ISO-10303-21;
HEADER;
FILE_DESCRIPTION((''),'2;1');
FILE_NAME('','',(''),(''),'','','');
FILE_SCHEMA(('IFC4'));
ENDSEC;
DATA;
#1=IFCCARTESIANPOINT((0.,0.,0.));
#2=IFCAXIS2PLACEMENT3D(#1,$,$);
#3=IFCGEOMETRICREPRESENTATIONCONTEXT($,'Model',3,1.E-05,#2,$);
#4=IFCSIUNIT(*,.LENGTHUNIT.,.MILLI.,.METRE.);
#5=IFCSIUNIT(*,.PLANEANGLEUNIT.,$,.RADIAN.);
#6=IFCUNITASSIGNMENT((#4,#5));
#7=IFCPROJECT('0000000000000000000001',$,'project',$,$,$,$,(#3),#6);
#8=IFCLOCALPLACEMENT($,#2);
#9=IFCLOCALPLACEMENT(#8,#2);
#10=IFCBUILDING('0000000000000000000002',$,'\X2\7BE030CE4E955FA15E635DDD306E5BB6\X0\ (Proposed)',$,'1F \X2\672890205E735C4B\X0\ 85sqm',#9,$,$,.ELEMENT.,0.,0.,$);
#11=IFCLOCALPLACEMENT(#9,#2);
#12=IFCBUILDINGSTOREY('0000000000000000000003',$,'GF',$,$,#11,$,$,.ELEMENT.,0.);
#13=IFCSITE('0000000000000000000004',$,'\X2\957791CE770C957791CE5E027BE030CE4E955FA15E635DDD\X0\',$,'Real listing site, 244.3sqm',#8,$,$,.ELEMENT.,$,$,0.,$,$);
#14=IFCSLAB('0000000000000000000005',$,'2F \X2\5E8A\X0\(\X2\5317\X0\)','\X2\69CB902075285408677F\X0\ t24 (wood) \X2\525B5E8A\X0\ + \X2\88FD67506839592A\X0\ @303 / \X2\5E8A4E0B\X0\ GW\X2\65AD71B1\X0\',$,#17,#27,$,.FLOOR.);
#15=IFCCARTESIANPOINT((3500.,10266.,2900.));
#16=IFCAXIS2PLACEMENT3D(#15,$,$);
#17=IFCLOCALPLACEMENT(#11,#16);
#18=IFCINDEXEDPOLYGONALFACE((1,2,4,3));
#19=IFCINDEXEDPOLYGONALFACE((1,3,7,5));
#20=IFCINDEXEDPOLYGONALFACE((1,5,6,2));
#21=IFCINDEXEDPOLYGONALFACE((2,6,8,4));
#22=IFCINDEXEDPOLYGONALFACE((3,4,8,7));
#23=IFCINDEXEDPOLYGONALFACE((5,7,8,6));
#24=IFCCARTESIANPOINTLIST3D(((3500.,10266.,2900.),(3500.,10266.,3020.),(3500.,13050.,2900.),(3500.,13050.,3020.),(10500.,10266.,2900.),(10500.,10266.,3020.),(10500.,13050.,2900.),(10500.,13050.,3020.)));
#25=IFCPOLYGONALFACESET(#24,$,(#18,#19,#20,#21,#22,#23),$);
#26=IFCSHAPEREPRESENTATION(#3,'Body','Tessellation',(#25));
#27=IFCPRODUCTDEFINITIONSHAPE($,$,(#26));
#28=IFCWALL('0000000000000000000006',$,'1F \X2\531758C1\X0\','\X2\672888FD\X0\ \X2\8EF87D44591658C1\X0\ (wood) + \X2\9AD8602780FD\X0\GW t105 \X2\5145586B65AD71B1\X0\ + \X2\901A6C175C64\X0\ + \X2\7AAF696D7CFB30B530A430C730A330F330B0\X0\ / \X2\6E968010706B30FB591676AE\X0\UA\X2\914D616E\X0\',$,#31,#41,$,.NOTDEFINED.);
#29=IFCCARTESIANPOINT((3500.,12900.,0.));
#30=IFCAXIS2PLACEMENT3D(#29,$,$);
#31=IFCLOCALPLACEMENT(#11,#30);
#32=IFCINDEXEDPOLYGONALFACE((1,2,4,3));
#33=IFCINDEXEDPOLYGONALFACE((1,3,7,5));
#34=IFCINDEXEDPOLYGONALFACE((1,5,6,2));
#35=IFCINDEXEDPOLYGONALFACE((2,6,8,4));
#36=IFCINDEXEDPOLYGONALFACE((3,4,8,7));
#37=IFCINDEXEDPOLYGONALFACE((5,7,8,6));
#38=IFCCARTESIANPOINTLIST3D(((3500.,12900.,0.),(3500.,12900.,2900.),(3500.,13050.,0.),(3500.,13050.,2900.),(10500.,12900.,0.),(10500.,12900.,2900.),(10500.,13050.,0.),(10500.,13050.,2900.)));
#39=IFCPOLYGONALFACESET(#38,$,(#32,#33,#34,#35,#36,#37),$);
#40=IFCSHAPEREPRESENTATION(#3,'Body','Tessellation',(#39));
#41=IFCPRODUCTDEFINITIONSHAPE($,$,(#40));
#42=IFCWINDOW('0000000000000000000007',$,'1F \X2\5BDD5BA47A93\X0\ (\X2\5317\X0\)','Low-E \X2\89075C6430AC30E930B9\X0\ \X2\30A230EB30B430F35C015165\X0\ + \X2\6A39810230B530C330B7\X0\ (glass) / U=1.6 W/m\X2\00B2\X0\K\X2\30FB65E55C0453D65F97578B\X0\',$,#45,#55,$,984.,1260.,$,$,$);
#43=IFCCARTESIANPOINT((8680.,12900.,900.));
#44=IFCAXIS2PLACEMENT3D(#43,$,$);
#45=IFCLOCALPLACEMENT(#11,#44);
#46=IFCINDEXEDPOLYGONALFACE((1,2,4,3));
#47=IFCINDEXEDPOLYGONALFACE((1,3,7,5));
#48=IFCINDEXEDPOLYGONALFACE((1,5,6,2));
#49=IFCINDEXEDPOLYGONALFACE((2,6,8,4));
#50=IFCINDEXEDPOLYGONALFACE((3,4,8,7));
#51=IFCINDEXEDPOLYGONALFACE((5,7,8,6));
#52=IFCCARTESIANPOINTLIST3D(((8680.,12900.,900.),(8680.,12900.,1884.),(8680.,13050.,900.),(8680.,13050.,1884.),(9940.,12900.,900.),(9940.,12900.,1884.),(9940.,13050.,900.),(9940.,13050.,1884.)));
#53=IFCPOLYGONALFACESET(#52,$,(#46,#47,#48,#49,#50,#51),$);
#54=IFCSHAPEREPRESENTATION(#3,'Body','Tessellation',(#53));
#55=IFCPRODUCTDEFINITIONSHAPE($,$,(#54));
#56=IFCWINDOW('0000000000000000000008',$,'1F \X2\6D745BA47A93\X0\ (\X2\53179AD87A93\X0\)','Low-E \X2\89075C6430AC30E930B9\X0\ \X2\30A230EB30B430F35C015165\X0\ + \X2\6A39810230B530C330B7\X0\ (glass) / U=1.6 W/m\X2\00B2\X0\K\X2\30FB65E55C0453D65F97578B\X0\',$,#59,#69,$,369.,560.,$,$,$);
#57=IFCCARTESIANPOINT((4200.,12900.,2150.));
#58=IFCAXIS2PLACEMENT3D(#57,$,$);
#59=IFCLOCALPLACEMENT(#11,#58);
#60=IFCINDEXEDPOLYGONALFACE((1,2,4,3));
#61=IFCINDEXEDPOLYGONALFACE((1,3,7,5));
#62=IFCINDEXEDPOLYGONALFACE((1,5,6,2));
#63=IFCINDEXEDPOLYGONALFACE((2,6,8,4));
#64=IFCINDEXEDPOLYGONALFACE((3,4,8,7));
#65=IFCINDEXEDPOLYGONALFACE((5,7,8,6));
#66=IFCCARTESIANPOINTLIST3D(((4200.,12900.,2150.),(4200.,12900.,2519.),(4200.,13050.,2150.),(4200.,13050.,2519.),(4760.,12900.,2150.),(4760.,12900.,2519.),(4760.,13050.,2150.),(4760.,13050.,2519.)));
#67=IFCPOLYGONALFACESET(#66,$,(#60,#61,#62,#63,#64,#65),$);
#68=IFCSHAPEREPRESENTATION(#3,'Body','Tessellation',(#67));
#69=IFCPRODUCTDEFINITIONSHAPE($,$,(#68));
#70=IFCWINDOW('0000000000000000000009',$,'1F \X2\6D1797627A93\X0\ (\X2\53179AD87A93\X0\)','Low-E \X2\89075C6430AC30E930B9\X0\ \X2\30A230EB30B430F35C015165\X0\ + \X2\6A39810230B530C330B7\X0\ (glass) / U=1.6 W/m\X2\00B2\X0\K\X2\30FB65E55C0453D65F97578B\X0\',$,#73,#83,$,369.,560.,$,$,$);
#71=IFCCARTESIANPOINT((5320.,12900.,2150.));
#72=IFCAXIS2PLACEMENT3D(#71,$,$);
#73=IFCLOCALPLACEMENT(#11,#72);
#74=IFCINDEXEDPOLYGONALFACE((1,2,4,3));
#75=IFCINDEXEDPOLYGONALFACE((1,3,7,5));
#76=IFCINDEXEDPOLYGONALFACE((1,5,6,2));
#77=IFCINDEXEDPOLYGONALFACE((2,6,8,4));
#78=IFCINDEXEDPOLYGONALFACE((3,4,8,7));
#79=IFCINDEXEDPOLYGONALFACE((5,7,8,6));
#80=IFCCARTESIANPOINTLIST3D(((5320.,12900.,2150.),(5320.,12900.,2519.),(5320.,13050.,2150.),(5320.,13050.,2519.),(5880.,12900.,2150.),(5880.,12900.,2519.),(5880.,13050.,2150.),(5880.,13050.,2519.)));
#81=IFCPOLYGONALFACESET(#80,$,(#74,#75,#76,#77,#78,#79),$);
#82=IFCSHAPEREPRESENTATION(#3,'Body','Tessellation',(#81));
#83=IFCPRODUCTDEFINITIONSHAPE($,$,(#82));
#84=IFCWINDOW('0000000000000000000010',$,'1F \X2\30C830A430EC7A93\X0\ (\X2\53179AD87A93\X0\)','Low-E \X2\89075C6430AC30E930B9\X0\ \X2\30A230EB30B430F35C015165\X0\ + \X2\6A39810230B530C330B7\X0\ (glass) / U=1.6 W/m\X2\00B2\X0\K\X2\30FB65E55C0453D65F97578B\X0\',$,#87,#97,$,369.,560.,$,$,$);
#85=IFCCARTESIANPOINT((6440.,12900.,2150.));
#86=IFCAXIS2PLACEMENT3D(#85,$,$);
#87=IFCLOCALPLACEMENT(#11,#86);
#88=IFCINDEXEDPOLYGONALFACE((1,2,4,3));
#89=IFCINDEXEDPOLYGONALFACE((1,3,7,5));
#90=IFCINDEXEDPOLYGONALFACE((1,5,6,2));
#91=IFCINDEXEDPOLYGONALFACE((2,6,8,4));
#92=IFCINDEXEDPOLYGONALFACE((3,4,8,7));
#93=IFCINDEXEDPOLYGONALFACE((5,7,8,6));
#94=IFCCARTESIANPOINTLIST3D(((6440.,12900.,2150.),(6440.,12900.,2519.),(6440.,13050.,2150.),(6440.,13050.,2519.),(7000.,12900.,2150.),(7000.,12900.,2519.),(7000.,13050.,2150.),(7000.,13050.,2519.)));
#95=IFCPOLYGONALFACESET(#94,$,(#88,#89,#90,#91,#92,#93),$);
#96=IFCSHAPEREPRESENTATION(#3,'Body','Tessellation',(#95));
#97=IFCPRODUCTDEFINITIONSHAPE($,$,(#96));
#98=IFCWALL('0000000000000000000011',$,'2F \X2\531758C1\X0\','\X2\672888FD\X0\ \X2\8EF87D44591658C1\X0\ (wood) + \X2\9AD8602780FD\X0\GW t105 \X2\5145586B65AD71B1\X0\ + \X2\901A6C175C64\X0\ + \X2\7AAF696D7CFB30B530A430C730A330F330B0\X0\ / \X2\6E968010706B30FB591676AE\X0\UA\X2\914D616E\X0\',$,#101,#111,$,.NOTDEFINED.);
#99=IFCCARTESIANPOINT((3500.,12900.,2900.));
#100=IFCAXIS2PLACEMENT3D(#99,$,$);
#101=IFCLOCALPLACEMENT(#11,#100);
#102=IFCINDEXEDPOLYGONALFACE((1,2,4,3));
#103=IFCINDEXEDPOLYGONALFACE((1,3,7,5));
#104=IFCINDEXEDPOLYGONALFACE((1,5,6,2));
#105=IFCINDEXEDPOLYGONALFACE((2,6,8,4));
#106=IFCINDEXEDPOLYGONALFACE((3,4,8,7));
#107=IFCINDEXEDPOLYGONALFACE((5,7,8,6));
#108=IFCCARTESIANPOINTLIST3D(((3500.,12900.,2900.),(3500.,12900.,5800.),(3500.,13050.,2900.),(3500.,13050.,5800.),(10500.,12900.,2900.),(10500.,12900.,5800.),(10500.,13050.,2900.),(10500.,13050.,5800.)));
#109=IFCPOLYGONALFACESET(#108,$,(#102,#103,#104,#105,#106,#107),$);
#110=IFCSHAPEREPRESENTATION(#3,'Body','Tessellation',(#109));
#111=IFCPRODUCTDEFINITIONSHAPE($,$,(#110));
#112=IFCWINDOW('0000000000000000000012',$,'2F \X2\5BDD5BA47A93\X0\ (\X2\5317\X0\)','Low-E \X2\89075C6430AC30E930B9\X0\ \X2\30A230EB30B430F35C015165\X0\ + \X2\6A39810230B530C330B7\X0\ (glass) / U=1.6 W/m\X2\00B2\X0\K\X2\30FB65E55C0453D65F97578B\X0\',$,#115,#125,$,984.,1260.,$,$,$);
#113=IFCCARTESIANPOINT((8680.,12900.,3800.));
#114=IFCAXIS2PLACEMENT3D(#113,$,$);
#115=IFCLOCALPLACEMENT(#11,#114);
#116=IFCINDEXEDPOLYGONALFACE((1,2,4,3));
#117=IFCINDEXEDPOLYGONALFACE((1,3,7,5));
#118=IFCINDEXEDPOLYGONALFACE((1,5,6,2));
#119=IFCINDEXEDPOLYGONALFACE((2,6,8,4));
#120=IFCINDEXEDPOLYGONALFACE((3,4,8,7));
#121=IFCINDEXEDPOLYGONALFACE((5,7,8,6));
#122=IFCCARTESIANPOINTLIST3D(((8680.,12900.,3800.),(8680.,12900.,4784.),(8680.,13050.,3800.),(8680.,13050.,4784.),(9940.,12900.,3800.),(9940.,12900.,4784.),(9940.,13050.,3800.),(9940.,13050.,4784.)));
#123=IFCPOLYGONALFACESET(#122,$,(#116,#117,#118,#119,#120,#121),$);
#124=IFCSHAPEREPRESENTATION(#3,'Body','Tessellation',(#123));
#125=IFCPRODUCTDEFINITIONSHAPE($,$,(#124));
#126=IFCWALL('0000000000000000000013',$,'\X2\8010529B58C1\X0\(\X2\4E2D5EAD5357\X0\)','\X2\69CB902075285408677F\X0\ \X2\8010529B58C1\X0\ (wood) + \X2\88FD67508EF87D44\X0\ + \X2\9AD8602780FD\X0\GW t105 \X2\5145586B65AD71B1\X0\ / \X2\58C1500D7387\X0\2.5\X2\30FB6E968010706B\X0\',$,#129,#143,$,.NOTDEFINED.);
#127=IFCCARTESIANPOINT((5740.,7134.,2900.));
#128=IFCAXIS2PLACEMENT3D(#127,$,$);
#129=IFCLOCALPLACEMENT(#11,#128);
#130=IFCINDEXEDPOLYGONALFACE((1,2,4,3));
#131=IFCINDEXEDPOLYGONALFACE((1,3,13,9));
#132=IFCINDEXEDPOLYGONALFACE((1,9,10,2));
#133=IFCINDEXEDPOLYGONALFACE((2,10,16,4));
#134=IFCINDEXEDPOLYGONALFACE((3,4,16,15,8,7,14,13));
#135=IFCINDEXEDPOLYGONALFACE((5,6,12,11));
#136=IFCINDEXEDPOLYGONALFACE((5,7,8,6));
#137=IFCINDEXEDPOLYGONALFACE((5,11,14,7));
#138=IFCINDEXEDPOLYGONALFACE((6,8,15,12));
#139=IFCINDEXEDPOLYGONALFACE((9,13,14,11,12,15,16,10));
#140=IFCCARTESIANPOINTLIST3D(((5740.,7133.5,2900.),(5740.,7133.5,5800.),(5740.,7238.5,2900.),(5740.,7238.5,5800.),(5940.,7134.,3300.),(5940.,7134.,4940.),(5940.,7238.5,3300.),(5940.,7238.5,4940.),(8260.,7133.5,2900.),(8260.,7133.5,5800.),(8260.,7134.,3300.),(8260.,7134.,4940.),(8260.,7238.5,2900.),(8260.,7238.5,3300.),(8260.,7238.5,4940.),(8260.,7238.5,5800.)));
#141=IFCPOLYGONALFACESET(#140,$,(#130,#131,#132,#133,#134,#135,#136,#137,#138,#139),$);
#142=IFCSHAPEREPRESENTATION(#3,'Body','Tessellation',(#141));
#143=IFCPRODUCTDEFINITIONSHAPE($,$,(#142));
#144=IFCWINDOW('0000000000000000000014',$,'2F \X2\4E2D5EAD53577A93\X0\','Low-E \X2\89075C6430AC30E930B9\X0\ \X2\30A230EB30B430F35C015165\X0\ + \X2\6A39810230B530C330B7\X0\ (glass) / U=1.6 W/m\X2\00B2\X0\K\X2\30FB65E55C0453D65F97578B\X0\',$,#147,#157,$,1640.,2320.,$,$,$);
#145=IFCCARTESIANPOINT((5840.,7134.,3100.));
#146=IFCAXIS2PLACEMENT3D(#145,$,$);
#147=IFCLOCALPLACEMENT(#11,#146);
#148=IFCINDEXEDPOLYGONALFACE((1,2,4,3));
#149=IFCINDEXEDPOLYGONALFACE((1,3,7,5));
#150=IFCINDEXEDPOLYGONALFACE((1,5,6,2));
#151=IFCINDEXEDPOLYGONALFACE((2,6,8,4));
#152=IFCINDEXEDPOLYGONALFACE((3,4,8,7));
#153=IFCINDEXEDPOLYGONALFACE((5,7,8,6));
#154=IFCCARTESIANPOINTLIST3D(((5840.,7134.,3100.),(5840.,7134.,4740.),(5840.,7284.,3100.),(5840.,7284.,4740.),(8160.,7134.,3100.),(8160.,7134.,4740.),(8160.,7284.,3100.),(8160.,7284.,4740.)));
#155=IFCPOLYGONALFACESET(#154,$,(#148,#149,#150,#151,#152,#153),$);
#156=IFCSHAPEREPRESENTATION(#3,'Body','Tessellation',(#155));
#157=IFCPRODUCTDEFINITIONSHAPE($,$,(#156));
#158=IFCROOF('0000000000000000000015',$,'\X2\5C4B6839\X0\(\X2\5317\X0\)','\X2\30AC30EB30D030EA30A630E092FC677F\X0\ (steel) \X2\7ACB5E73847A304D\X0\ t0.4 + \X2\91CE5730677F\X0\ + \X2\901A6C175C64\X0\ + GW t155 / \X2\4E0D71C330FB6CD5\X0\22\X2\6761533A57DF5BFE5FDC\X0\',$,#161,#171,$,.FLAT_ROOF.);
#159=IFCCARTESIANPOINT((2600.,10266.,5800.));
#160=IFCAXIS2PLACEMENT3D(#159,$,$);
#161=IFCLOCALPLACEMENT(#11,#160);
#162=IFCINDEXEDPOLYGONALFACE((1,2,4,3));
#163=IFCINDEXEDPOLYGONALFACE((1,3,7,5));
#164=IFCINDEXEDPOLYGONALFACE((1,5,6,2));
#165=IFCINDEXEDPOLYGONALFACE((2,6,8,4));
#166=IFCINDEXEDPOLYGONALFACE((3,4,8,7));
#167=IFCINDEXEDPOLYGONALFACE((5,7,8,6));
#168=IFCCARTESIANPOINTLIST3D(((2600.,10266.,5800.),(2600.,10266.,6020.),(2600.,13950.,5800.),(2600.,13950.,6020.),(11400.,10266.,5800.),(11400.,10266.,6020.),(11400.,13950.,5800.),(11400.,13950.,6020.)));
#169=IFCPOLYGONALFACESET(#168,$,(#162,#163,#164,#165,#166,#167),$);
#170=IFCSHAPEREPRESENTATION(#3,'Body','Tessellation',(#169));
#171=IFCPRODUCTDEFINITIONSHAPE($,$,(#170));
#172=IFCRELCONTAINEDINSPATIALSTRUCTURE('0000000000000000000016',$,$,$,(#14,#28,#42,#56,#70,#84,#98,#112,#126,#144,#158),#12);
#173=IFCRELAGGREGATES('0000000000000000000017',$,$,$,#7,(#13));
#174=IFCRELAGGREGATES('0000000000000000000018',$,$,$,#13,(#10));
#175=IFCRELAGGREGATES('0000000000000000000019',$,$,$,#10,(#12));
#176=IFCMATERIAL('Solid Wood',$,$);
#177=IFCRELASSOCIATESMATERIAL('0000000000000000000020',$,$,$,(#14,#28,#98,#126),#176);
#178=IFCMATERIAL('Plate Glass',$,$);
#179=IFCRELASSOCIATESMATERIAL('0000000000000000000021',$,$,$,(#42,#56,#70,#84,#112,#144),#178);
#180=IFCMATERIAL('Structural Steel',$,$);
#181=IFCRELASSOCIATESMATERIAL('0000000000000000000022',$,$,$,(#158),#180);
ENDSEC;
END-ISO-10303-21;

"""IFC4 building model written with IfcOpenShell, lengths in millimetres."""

from ifc_helpers import new_model, si_unit, frame, frame_2d, origin, place, context, project, spatial, rectangle, extrude, material, element, fill, save


model = new_model("IFC4")

# Units and contexts
model_context = context("Model", 3, precision=1e-05, world=origin())
ifc_project = project(units=[si_unit("LENGTHUNIT", "METRE", prefix="MILLI"), si_unit("PLANEANGLEUNIT", "RADIAN")], contexts=[model_context])

# Site, building, storey
site_placement = place(None, origin())
site = spatial("IfcSite", under=ifc_project, at=site_placement, Name="長野県長野市篠ノ井御幣川", ObjectType="Real listing site, 244.3sqm", CompositionType="ELEMENT", RefElevation=0.0)
building_placement = place(site_placement, origin())
building = spatial("IfcBuilding", under=site, at=building_placement, Name="篠ノ井御幣川の家 (Proposed)", ObjectType="1F 木造平屋 85sqm", CompositionType="ELEMENT", ElevationOfRefHeight=0.0, ElevationOfTerrain=0.0)
storey_placement = place(building_placement, origin())
storey = spatial("IfcBuildingStorey", under=building, at=storey_placement, Name="GF", CompositionType="ELEMENT", Elevation=0.0)

# Slab
ifc_material_1 = material(Name="Solid Wood")
slab_1_placement = place(storey_placement, frame((3500.0, 10266.0, 2900.0)))
element("IfcSlab", 1, at=slab_1_placement, inside=storey, material=ifc_material_1, Name="2F 床(北)", Description="構造用合板 t24 (wood) 剛床 + 製材根太 @303 / 床下 GW断熱", PredefinedType="FLOOR", context=model_context, shape_type="SweptSolid", body=[
    extrude(rectangle(XDim=7000.0, YDim=2784.0, at=frame_2d((3500.0, 1392.0))), frame((3500.0, 10266.0, 2900.0)), (0.0, 0.0, 1.0), 120.0),
])

# Wall, openings, windows
wall_1_placement = place(storey_placement, frame((3500.0, 12900.0, 0.0)))
wall_1 = element("IfcWall", 2, at=wall_1_placement, inside=storey, material=ifc_material_1, Name="1F 北壁", Description="木製 軸組外壁 (wood) + 高性能GW t105 充填断熱 + 通気層 + 窯業系サイディング / 準耐火・外皮UA配慮", PredefinedType="NOTDEFINED", context=model_context, shape_type="SweptSolid", body=[
    extrude(rectangle(XDim=7000.0, YDim=150.0, at=frame_2d((3500.0, 75.0))), frame((3500.0, 12900.0, 0.0)), (0.0, 0.0, 1.0), 2900.0),
])
opening_1_placement = place(storey_placement, frame((8680.0, 12900.0, 900.0)))
opening_1 = element("IfcOpeningElement", 3, at=opening_1_placement, cuts=wall_1, PredefinedType="NOTDEFINED", context=model_context, shape_type="SweptSolid", body=[
    extrude(rectangle(XDim=1260.0, YDim=150.0, at=frame_2d((630.0, 75.0))), frame((8680.0, 12900.0, 900.0)), (0.0, 0.0, 1.0), 984.0),
])
opening_2_placement = place(storey_placement, frame((4200.0, 12900.0, 2150.0)))
opening_2 = element("IfcOpeningElement", 4, at=opening_2_placement, cuts=wall_1, PredefinedType="NOTDEFINED", context=model_context, shape_type="SweptSolid", body=[
    extrude(rectangle(XDim=560.0, YDim=150.0, at=frame_2d((280.0, 75.0))), frame((4200.0, 12900.0, 2150.0)), (0.0, 0.0, 1.0), 369.0),
])
opening_3_placement = place(storey_placement, frame((5320.0, 12900.0, 2150.0)))
opening_3 = element("IfcOpeningElement", 5, at=opening_3_placement, cuts=wall_1, PredefinedType="NOTDEFINED", context=model_context, shape_type="SweptSolid", body=[
    extrude(rectangle(XDim=560.0, YDim=150.0, at=frame_2d((280.0, 75.0))), frame((5320.0, 12900.0, 2150.0)), (0.0, 0.0, 1.0), 369.0),
])
opening_4_placement = place(storey_placement, frame((6440.0, 12900.0, 2150.0)))
opening_4 = element("IfcOpeningElement", 6, at=opening_4_placement, cuts=wall_1, PredefinedType="NOTDEFINED", context=model_context, shape_type="SweptSolid", body=[
    extrude(rectangle(XDim=560.0, YDim=150.0, at=frame_2d((280.0, 75.0))), frame((6440.0, 12900.0, 2150.0)), (0.0, 0.0, 1.0), 369.0),
])
ifc_material_2 = material(Name="Plate Glass")
window_1_placement = place(storey_placement, frame((8680.0, 12900.0, 900.0)))
window_1 = element("IfcWindow", 7, at=window_1_placement, inside=storey, material=ifc_material_2, Name="1F 寝室窓 (北)", Description="Low-E 複層ガラス アルゴン封入 + 樹脂サッシ (glass) / U=1.6 W/m²K・日射取得型", OverallHeight=984.0, OverallWidth=1260.0, context=model_context, shape_type="SweptSolid", body=[
    extrude(rectangle(XDim=1260.0, YDim=150.0, at=frame_2d((630.0, 75.0))), frame((8680.0, 12900.0, 900.0)), (0.0, 0.0, 1.0), 984.0),
])
fill(opening_1, window_1)
window_2_placement = place(storey_placement, frame((4200.0, 12900.0, 2150.0)))
window_2 = element("IfcWindow", 8, at=window_2_placement, inside=storey, material=ifc_material_2, Name="1F 浴室窓 (北高窓)", Description="Low-E 複層ガラス アルゴン封入 + 樹脂サッシ (glass) / U=1.6 W/m²K・日射取得型", OverallHeight=369.0, OverallWidth=560.0, context=model_context, shape_type="SweptSolid", body=[
    extrude(rectangle(XDim=560.0, YDim=150.0, at=frame_2d((280.0, 75.0))), frame((4200.0, 12900.0, 2150.0)), (0.0, 0.0, 1.0), 369.0),
])
fill(opening_2, window_2)
window_3_placement = place(storey_placement, frame((5320.0, 12900.0, 2150.0)))
window_3 = element("IfcWindow", 9, at=window_3_placement, inside=storey, material=ifc_material_2, Name="1F 洗面窓 (北高窓)", Description="Low-E 複層ガラス アルゴン封入 + 樹脂サッシ (glass) / U=1.6 W/m²K・日射取得型", OverallHeight=369.0, OverallWidth=560.0, context=model_context, shape_type="SweptSolid", body=[
    extrude(rectangle(XDim=560.0, YDim=150.0, at=frame_2d((280.0, 75.0))), frame((5320.0, 12900.0, 2150.0)), (0.0, 0.0, 1.0), 369.0),
])
fill(opening_3, window_3)
window_4_placement = place(storey_placement, frame((6440.0, 12900.0, 2150.0)))
window_4 = element("IfcWindow", 10, at=window_4_placement, inside=storey, material=ifc_material_2, Name="1F トイレ窓 (北高窓)", Description="Low-E 複層ガラス アルゴン封入 + 樹脂サッシ (glass) / U=1.6 W/m²K・日射取得型", OverallHeight=369.0, OverallWidth=560.0, context=model_context, shape_type="SweptSolid", body=[
    extrude(rectangle(XDim=560.0, YDim=150.0, at=frame_2d((280.0, 75.0))), frame((6440.0, 12900.0, 2150.0)), (0.0, 0.0, 1.0), 369.0),
])
fill(opening_4, window_4)

# Walls, openings, windows
wall_2_placement = place(storey_placement, frame((3500.0, 12900.0, 2900.0)))
wall_2 = element("IfcWall", 11, at=wall_2_placement, inside=storey, material=ifc_material_1, Name="2F 北壁", Description="木製 軸組外壁 (wood) + 高性能GW t105 充填断熱 + 通気層 + 窯業系サイディング / 準耐火・外皮UA配慮", PredefinedType="NOTDEFINED", context=model_context, shape_type="SweptSolid", body=[
    extrude(rectangle(XDim=7000.0, YDim=150.0, at=frame_2d((3500.0, 75.0))), frame((3500.0, 12900.0, 2900.0)), (0.0, 0.0, 1.0), 2900.0),
])
opening_5_placement = place(storey_placement, frame((8680.0, 12900.0, 3800.0)))
opening_5 = element("IfcOpeningElement", 12, at=opening_5_placement, cuts=wall_2, PredefinedType="NOTDEFINED", context=model_context, shape_type="SweptSolid", body=[
    extrude(rectangle(XDim=1260.0, YDim=150.0, at=frame_2d((630.0, 75.0))), frame((8680.0, 12900.0, 3800.0)), (0.0, 0.0, 1.0), 984.0),
])
window_5_placement = place(storey_placement, frame((8680.0, 12900.0, 3800.0)))
window_5 = element("IfcWindow", 13, at=window_5_placement, inside=storey, material=ifc_material_2, Name="2F 寝室窓 (北)", Description="Low-E 複層ガラス アルゴン封入 + 樹脂サッシ (glass) / U=1.6 W/m²K・日射取得型", OverallHeight=984.0, OverallWidth=1260.0, context=model_context, shape_type="SweptSolid", body=[
    extrude(rectangle(XDim=1260.0, YDim=150.0, at=frame_2d((630.0, 75.0))), frame((8680.0, 12900.0, 3800.0)), (0.0, 0.0, 1.0), 984.0),
])
fill(opening_5, window_5)
wall_3_placement = place(storey_placement, frame((5740.0, 7134.0, 2900.0)))
wall_3 = element("IfcWall", 14, at=wall_3_placement, inside=storey, material=ifc_material_1, Name="耐力壁(中庭南)", Description="構造用合板 耐力壁 (wood) + 製材軸組 + 高性能GW t105 充填断熱 / 壁倍率2.5・準耐火", PredefinedType="NOTDEFINED", context=model_context, shape_type="SweptSolid", body=[
    extrude(rectangle(XDim=2520.0, YDim=105.0, at=frame_2d((1260.0, 52.0))), frame((5740.0, 7134.0, 2900.0)), (0.0, 0.0, 1.0), 2900.0),
])
opening_6_placement = place(storey_placement, frame((5840.0, 7134.0, 3100.0)))
opening_6 = element("IfcOpeningElement", 15, at=opening_6_placement, cuts=wall_3, PredefinedType="NOTDEFINED", context=model_context, shape_type="SweptSolid", body=[
    extrude(rectangle(XDim=2320.0, YDim=150.0, at=frame_2d((1160.0, 75.0))), frame((5840.0, 7134.0, 3100.0)), (0.0, 0.0, 1.0), 1640.0),
])
window_6_placement = place(storey_placement, frame((5840.0, 7134.0, 3100.0)))
window_6 = element("IfcWindow", 16, at=window_6_placement, inside=storey, material=ifc_material_2, Name="2F 中庭南窓", Description="Low-E 複層ガラス アルゴン封入 + 樹脂サッシ (glass) / U=1.6 W/m²K・日射取得型", OverallHeight=1640.0, OverallWidth=2320.0, context=model_context, shape_type="SweptSolid", body=[
    extrude(rectangle(XDim=2320.0, YDim=150.0, at=frame_2d((1160.0, 75.0))), frame((5840.0, 7134.0, 3100.0)), (0.0, 0.0, 1.0), 1640.0),
])
fill(opening_6, window_6)

# Roof
ifc_material_3 = material(Name="Structural Steel")
for number, where, name in (
    (17, (2600.0, 10266.0, 5800.0), "屋根(北)"),
):
    element("IfcRoof", number, at=place(storey_placement, frame(where)), inside=storey, material=ifc_material_3, Name=name, Description="ガルバリウム鋼板 (steel) 立平葺き t0.4 + 野地板 + 通気層 + GW t155 / 不燃・法22条区域対応", PredefinedType="FLAT_ROOF", context=model_context, shape_type="SweptSolid", body=[
        extrude(rectangle(XDim=8800.0, YDim=3684.0, at=frame_2d((4400.0, 1842.0))), frame((2600.0, 10266.0, 5800.0)), (0.0, 0.0, 1.0), 220.0),
    ])

save(model, "model.ifc")
